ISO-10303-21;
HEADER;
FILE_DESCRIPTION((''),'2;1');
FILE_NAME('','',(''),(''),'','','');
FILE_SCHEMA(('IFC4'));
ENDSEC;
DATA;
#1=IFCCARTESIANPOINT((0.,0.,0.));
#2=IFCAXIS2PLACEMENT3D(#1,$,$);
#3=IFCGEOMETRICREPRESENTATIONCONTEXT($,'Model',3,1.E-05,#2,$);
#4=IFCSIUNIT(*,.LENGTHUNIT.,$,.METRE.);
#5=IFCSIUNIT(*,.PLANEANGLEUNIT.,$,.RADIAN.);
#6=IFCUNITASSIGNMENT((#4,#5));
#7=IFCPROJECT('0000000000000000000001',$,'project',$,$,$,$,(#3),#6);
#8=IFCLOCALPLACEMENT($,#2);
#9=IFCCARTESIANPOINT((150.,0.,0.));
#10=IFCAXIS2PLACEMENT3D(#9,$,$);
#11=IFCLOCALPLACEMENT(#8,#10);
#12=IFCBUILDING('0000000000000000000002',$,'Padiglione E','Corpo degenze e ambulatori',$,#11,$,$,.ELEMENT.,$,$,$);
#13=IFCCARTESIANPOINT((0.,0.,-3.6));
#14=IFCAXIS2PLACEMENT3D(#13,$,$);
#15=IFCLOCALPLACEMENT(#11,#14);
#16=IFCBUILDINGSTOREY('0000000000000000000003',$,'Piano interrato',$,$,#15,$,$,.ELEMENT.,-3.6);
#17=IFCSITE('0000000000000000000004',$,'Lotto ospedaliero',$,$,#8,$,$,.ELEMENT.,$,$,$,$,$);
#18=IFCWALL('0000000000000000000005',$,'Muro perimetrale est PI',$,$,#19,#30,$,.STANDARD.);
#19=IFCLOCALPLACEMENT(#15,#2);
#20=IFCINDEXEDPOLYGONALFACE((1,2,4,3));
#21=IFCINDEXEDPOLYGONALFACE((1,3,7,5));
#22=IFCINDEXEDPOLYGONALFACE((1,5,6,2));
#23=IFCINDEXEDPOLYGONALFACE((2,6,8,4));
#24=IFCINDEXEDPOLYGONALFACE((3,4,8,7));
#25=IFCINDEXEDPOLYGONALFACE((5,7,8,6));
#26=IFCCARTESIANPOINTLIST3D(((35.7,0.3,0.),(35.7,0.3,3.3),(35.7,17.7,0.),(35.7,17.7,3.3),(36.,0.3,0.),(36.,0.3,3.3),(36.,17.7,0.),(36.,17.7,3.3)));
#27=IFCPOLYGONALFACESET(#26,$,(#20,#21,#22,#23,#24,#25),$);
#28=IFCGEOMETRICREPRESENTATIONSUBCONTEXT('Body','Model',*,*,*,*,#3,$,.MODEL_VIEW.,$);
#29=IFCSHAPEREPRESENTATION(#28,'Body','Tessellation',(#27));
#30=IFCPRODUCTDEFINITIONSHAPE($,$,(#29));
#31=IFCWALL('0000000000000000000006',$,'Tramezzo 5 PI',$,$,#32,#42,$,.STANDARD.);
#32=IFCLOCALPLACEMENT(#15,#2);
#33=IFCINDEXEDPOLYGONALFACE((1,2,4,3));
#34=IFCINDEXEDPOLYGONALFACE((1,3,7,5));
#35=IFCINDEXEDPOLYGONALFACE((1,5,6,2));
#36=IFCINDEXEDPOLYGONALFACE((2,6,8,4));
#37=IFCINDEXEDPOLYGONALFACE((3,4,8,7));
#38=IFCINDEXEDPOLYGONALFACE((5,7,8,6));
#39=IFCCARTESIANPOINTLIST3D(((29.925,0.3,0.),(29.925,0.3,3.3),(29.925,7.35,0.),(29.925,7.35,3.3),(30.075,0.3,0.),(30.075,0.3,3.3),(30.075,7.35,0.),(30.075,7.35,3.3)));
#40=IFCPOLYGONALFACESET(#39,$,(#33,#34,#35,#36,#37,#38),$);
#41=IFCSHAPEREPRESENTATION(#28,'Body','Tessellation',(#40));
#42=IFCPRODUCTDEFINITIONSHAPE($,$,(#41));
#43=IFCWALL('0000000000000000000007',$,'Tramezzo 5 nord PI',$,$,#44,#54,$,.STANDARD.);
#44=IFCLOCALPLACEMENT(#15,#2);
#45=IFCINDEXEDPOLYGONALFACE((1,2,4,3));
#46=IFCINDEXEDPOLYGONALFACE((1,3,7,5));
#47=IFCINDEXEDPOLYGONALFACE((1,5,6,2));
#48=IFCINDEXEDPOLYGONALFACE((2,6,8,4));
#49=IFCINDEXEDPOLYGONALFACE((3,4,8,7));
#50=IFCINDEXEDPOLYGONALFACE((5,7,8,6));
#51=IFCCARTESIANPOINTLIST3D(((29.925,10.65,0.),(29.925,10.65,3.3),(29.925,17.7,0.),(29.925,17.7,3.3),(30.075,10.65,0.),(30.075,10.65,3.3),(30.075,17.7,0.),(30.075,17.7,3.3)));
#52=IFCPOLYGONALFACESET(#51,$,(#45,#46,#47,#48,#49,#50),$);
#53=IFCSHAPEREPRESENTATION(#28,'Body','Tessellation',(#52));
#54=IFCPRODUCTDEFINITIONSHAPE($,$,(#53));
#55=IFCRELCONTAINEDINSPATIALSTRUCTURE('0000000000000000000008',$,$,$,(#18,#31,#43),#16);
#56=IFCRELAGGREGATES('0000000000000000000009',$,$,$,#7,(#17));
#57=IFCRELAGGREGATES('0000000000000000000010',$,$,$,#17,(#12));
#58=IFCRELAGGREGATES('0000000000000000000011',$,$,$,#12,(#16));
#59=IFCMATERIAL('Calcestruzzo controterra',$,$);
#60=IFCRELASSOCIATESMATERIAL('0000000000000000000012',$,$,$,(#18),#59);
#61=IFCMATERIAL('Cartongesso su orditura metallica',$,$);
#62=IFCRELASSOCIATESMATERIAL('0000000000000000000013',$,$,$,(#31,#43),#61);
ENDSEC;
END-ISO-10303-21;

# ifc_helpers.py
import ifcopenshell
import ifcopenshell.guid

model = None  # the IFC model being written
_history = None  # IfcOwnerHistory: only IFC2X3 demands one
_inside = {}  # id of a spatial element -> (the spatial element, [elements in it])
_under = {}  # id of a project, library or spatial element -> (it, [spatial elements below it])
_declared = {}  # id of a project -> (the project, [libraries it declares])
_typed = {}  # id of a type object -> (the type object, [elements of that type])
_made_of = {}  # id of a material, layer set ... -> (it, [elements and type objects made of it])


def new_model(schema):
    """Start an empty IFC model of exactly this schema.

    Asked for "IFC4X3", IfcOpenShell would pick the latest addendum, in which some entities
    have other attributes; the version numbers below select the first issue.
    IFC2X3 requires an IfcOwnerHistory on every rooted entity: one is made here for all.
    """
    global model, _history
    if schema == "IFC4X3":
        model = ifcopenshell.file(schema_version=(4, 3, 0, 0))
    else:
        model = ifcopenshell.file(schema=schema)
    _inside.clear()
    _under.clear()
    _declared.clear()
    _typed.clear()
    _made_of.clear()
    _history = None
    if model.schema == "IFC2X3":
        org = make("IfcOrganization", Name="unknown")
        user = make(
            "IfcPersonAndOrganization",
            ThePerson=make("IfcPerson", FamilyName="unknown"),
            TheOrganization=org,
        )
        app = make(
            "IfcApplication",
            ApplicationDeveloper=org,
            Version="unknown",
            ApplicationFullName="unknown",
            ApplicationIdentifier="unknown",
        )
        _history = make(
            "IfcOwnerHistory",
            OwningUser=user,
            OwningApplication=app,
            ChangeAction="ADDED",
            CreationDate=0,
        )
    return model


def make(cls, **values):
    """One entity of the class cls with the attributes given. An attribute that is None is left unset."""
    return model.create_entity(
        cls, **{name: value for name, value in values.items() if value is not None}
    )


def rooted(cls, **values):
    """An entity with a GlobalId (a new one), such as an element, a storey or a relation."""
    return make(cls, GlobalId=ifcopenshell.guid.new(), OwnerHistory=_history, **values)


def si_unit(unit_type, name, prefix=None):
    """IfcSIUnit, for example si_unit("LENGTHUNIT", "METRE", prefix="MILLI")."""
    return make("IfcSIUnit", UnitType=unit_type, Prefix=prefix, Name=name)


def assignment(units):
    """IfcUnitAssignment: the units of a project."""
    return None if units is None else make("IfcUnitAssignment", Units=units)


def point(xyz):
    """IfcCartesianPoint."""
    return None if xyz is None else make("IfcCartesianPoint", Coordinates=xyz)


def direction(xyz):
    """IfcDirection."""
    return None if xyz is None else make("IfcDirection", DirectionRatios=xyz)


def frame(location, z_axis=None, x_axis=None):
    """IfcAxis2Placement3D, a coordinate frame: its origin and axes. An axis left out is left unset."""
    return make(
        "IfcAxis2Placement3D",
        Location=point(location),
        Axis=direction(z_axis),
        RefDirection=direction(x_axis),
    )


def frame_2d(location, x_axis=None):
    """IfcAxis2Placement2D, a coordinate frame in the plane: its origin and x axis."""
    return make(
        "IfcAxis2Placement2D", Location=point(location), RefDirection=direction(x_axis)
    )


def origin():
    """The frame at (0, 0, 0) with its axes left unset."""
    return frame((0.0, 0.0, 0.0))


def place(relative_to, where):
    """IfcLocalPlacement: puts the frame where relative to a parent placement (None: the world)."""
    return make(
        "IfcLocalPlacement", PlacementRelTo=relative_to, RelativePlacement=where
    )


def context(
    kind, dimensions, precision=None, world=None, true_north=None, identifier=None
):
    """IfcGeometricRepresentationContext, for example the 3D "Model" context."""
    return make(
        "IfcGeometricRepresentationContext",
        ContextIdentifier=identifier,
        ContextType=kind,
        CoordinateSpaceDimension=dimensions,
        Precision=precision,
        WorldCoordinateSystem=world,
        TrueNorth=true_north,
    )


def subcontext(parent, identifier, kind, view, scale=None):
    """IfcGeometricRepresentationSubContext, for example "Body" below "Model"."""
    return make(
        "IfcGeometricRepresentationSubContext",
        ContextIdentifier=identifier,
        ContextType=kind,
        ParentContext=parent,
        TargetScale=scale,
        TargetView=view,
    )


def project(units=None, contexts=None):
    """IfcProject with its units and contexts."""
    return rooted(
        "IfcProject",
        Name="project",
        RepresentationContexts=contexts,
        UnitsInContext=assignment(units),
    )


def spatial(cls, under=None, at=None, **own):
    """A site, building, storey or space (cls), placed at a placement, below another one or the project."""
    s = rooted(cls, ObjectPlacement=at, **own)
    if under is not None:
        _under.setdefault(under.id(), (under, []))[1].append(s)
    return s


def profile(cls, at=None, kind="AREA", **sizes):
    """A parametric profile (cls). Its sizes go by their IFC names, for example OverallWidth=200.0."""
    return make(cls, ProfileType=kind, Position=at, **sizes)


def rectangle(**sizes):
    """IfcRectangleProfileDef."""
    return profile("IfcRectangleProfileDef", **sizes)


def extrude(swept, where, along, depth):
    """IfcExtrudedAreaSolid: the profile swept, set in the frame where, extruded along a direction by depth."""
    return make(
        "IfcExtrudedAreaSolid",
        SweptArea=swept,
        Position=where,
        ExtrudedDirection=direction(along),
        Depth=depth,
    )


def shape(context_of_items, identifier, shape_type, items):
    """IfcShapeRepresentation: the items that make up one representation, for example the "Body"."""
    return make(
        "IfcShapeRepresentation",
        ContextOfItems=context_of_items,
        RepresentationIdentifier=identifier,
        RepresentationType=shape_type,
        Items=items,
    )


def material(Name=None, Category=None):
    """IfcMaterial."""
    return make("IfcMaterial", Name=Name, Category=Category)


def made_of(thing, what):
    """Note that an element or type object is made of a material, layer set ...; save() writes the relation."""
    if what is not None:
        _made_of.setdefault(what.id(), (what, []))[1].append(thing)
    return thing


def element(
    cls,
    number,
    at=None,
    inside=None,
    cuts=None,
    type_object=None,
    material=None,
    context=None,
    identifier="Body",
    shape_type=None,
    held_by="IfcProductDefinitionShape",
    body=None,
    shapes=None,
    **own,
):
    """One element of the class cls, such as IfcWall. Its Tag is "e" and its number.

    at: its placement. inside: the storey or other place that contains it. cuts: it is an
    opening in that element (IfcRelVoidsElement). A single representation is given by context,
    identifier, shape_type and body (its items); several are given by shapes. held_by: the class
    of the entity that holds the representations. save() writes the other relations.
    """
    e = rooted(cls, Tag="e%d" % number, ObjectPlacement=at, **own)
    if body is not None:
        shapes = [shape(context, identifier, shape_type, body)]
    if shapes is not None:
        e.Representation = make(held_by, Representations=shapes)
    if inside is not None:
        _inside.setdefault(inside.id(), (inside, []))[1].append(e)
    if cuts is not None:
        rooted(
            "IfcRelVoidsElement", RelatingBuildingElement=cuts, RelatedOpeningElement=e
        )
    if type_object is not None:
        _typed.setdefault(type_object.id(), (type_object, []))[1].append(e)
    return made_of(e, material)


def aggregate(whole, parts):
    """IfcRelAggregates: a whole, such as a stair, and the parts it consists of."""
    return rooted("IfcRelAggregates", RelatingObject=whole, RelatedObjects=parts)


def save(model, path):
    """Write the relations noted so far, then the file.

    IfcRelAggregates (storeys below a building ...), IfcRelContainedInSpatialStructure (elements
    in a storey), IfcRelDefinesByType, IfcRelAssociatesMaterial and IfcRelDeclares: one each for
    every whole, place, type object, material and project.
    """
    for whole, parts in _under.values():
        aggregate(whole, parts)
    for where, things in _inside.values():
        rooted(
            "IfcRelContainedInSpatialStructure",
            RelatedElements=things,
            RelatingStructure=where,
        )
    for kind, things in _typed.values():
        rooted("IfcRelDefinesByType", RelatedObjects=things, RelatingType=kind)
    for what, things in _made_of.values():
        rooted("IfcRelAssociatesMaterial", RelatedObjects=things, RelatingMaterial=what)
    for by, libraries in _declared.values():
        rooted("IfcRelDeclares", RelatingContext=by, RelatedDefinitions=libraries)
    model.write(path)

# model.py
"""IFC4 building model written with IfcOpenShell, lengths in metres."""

from ifc_helpers import new_model, si_unit, frame, frame_2d, origin, place, context, subcontext, project, spatial, rectangle, extrude, material, element, save


model = new_model("IFC4")

# Units and contexts
model_context = context("Model", 3, precision=1e-05, world=origin())
body_context = subcontext(model_context, "Body", "Model", "MODEL_VIEW")
ifc_project = project(units=[si_unit("LENGTHUNIT", "METRE"), si_unit("PLANEANGLEUNIT", "RADIAN")], contexts=[model_context])

# Site, building, storey
site_placement = place(None, origin())
site = spatial("IfcSite", under=ifc_project, at=site_placement, Name="Lotto ospedaliero", CompositionType="ELEMENT")
building_placement = place(site_placement, frame((150.0, 0.0, 0.0)))
building = spatial("IfcBuilding", under=site, at=building_placement, Name="Padiglione E", Description="Corpo degenze e ambulatori", CompositionType="ELEMENT")
storey_placement = place(building_placement, frame((0.0, 0.0, -3.6)))
storey = spatial("IfcBuildingStorey", under=building, at=storey_placement, Name="Piano interrato", CompositionType="ELEMENT", Elevation=-3.6)

# Walls
ifc_material_1 = material(Name="Calcestruzzo controterra")
wall_placement = place(storey_placement, frame((35.7, 0.3, 0.0)))
element("IfcWall", 1, at=wall_placement, inside=storey, material=ifc_material_1, Name="Muro perimetrale est PI", PredefinedType="STANDARD", context=body_context, shape_type="SweptSolid", body=[
    extrude(rectangle(XDim=0.3, YDim=17.4, at=frame_2d((0.15, 8.7))), origin(), (0.0, 0.0, 1.0), 3.3),
])
ifc_material_2 = material(Name="Cartongesso su orditura metallica")
for number, where, name in (
    (2, (29.925, 0.3, 0.0), "Tramezzo 5 PI"),
    (3, (29.925, 10.65, 0.0), "Tramezzo 5 nord PI"),
):
    element("IfcWall", number, at=place(storey_placement, frame(where)), inside=storey, material=ifc_material_2, Name=name, PredefinedType="STANDARD", context=body_context, shape_type="SweptSolid", body=[
        extrude(rectangle(XDim=0.15, YDim=7.05, at=frame_2d((0.075, 3.525))), origin(), (0.0, 0.0, 1.0), 3.3),
    ])

save(model, "model.ifc")
